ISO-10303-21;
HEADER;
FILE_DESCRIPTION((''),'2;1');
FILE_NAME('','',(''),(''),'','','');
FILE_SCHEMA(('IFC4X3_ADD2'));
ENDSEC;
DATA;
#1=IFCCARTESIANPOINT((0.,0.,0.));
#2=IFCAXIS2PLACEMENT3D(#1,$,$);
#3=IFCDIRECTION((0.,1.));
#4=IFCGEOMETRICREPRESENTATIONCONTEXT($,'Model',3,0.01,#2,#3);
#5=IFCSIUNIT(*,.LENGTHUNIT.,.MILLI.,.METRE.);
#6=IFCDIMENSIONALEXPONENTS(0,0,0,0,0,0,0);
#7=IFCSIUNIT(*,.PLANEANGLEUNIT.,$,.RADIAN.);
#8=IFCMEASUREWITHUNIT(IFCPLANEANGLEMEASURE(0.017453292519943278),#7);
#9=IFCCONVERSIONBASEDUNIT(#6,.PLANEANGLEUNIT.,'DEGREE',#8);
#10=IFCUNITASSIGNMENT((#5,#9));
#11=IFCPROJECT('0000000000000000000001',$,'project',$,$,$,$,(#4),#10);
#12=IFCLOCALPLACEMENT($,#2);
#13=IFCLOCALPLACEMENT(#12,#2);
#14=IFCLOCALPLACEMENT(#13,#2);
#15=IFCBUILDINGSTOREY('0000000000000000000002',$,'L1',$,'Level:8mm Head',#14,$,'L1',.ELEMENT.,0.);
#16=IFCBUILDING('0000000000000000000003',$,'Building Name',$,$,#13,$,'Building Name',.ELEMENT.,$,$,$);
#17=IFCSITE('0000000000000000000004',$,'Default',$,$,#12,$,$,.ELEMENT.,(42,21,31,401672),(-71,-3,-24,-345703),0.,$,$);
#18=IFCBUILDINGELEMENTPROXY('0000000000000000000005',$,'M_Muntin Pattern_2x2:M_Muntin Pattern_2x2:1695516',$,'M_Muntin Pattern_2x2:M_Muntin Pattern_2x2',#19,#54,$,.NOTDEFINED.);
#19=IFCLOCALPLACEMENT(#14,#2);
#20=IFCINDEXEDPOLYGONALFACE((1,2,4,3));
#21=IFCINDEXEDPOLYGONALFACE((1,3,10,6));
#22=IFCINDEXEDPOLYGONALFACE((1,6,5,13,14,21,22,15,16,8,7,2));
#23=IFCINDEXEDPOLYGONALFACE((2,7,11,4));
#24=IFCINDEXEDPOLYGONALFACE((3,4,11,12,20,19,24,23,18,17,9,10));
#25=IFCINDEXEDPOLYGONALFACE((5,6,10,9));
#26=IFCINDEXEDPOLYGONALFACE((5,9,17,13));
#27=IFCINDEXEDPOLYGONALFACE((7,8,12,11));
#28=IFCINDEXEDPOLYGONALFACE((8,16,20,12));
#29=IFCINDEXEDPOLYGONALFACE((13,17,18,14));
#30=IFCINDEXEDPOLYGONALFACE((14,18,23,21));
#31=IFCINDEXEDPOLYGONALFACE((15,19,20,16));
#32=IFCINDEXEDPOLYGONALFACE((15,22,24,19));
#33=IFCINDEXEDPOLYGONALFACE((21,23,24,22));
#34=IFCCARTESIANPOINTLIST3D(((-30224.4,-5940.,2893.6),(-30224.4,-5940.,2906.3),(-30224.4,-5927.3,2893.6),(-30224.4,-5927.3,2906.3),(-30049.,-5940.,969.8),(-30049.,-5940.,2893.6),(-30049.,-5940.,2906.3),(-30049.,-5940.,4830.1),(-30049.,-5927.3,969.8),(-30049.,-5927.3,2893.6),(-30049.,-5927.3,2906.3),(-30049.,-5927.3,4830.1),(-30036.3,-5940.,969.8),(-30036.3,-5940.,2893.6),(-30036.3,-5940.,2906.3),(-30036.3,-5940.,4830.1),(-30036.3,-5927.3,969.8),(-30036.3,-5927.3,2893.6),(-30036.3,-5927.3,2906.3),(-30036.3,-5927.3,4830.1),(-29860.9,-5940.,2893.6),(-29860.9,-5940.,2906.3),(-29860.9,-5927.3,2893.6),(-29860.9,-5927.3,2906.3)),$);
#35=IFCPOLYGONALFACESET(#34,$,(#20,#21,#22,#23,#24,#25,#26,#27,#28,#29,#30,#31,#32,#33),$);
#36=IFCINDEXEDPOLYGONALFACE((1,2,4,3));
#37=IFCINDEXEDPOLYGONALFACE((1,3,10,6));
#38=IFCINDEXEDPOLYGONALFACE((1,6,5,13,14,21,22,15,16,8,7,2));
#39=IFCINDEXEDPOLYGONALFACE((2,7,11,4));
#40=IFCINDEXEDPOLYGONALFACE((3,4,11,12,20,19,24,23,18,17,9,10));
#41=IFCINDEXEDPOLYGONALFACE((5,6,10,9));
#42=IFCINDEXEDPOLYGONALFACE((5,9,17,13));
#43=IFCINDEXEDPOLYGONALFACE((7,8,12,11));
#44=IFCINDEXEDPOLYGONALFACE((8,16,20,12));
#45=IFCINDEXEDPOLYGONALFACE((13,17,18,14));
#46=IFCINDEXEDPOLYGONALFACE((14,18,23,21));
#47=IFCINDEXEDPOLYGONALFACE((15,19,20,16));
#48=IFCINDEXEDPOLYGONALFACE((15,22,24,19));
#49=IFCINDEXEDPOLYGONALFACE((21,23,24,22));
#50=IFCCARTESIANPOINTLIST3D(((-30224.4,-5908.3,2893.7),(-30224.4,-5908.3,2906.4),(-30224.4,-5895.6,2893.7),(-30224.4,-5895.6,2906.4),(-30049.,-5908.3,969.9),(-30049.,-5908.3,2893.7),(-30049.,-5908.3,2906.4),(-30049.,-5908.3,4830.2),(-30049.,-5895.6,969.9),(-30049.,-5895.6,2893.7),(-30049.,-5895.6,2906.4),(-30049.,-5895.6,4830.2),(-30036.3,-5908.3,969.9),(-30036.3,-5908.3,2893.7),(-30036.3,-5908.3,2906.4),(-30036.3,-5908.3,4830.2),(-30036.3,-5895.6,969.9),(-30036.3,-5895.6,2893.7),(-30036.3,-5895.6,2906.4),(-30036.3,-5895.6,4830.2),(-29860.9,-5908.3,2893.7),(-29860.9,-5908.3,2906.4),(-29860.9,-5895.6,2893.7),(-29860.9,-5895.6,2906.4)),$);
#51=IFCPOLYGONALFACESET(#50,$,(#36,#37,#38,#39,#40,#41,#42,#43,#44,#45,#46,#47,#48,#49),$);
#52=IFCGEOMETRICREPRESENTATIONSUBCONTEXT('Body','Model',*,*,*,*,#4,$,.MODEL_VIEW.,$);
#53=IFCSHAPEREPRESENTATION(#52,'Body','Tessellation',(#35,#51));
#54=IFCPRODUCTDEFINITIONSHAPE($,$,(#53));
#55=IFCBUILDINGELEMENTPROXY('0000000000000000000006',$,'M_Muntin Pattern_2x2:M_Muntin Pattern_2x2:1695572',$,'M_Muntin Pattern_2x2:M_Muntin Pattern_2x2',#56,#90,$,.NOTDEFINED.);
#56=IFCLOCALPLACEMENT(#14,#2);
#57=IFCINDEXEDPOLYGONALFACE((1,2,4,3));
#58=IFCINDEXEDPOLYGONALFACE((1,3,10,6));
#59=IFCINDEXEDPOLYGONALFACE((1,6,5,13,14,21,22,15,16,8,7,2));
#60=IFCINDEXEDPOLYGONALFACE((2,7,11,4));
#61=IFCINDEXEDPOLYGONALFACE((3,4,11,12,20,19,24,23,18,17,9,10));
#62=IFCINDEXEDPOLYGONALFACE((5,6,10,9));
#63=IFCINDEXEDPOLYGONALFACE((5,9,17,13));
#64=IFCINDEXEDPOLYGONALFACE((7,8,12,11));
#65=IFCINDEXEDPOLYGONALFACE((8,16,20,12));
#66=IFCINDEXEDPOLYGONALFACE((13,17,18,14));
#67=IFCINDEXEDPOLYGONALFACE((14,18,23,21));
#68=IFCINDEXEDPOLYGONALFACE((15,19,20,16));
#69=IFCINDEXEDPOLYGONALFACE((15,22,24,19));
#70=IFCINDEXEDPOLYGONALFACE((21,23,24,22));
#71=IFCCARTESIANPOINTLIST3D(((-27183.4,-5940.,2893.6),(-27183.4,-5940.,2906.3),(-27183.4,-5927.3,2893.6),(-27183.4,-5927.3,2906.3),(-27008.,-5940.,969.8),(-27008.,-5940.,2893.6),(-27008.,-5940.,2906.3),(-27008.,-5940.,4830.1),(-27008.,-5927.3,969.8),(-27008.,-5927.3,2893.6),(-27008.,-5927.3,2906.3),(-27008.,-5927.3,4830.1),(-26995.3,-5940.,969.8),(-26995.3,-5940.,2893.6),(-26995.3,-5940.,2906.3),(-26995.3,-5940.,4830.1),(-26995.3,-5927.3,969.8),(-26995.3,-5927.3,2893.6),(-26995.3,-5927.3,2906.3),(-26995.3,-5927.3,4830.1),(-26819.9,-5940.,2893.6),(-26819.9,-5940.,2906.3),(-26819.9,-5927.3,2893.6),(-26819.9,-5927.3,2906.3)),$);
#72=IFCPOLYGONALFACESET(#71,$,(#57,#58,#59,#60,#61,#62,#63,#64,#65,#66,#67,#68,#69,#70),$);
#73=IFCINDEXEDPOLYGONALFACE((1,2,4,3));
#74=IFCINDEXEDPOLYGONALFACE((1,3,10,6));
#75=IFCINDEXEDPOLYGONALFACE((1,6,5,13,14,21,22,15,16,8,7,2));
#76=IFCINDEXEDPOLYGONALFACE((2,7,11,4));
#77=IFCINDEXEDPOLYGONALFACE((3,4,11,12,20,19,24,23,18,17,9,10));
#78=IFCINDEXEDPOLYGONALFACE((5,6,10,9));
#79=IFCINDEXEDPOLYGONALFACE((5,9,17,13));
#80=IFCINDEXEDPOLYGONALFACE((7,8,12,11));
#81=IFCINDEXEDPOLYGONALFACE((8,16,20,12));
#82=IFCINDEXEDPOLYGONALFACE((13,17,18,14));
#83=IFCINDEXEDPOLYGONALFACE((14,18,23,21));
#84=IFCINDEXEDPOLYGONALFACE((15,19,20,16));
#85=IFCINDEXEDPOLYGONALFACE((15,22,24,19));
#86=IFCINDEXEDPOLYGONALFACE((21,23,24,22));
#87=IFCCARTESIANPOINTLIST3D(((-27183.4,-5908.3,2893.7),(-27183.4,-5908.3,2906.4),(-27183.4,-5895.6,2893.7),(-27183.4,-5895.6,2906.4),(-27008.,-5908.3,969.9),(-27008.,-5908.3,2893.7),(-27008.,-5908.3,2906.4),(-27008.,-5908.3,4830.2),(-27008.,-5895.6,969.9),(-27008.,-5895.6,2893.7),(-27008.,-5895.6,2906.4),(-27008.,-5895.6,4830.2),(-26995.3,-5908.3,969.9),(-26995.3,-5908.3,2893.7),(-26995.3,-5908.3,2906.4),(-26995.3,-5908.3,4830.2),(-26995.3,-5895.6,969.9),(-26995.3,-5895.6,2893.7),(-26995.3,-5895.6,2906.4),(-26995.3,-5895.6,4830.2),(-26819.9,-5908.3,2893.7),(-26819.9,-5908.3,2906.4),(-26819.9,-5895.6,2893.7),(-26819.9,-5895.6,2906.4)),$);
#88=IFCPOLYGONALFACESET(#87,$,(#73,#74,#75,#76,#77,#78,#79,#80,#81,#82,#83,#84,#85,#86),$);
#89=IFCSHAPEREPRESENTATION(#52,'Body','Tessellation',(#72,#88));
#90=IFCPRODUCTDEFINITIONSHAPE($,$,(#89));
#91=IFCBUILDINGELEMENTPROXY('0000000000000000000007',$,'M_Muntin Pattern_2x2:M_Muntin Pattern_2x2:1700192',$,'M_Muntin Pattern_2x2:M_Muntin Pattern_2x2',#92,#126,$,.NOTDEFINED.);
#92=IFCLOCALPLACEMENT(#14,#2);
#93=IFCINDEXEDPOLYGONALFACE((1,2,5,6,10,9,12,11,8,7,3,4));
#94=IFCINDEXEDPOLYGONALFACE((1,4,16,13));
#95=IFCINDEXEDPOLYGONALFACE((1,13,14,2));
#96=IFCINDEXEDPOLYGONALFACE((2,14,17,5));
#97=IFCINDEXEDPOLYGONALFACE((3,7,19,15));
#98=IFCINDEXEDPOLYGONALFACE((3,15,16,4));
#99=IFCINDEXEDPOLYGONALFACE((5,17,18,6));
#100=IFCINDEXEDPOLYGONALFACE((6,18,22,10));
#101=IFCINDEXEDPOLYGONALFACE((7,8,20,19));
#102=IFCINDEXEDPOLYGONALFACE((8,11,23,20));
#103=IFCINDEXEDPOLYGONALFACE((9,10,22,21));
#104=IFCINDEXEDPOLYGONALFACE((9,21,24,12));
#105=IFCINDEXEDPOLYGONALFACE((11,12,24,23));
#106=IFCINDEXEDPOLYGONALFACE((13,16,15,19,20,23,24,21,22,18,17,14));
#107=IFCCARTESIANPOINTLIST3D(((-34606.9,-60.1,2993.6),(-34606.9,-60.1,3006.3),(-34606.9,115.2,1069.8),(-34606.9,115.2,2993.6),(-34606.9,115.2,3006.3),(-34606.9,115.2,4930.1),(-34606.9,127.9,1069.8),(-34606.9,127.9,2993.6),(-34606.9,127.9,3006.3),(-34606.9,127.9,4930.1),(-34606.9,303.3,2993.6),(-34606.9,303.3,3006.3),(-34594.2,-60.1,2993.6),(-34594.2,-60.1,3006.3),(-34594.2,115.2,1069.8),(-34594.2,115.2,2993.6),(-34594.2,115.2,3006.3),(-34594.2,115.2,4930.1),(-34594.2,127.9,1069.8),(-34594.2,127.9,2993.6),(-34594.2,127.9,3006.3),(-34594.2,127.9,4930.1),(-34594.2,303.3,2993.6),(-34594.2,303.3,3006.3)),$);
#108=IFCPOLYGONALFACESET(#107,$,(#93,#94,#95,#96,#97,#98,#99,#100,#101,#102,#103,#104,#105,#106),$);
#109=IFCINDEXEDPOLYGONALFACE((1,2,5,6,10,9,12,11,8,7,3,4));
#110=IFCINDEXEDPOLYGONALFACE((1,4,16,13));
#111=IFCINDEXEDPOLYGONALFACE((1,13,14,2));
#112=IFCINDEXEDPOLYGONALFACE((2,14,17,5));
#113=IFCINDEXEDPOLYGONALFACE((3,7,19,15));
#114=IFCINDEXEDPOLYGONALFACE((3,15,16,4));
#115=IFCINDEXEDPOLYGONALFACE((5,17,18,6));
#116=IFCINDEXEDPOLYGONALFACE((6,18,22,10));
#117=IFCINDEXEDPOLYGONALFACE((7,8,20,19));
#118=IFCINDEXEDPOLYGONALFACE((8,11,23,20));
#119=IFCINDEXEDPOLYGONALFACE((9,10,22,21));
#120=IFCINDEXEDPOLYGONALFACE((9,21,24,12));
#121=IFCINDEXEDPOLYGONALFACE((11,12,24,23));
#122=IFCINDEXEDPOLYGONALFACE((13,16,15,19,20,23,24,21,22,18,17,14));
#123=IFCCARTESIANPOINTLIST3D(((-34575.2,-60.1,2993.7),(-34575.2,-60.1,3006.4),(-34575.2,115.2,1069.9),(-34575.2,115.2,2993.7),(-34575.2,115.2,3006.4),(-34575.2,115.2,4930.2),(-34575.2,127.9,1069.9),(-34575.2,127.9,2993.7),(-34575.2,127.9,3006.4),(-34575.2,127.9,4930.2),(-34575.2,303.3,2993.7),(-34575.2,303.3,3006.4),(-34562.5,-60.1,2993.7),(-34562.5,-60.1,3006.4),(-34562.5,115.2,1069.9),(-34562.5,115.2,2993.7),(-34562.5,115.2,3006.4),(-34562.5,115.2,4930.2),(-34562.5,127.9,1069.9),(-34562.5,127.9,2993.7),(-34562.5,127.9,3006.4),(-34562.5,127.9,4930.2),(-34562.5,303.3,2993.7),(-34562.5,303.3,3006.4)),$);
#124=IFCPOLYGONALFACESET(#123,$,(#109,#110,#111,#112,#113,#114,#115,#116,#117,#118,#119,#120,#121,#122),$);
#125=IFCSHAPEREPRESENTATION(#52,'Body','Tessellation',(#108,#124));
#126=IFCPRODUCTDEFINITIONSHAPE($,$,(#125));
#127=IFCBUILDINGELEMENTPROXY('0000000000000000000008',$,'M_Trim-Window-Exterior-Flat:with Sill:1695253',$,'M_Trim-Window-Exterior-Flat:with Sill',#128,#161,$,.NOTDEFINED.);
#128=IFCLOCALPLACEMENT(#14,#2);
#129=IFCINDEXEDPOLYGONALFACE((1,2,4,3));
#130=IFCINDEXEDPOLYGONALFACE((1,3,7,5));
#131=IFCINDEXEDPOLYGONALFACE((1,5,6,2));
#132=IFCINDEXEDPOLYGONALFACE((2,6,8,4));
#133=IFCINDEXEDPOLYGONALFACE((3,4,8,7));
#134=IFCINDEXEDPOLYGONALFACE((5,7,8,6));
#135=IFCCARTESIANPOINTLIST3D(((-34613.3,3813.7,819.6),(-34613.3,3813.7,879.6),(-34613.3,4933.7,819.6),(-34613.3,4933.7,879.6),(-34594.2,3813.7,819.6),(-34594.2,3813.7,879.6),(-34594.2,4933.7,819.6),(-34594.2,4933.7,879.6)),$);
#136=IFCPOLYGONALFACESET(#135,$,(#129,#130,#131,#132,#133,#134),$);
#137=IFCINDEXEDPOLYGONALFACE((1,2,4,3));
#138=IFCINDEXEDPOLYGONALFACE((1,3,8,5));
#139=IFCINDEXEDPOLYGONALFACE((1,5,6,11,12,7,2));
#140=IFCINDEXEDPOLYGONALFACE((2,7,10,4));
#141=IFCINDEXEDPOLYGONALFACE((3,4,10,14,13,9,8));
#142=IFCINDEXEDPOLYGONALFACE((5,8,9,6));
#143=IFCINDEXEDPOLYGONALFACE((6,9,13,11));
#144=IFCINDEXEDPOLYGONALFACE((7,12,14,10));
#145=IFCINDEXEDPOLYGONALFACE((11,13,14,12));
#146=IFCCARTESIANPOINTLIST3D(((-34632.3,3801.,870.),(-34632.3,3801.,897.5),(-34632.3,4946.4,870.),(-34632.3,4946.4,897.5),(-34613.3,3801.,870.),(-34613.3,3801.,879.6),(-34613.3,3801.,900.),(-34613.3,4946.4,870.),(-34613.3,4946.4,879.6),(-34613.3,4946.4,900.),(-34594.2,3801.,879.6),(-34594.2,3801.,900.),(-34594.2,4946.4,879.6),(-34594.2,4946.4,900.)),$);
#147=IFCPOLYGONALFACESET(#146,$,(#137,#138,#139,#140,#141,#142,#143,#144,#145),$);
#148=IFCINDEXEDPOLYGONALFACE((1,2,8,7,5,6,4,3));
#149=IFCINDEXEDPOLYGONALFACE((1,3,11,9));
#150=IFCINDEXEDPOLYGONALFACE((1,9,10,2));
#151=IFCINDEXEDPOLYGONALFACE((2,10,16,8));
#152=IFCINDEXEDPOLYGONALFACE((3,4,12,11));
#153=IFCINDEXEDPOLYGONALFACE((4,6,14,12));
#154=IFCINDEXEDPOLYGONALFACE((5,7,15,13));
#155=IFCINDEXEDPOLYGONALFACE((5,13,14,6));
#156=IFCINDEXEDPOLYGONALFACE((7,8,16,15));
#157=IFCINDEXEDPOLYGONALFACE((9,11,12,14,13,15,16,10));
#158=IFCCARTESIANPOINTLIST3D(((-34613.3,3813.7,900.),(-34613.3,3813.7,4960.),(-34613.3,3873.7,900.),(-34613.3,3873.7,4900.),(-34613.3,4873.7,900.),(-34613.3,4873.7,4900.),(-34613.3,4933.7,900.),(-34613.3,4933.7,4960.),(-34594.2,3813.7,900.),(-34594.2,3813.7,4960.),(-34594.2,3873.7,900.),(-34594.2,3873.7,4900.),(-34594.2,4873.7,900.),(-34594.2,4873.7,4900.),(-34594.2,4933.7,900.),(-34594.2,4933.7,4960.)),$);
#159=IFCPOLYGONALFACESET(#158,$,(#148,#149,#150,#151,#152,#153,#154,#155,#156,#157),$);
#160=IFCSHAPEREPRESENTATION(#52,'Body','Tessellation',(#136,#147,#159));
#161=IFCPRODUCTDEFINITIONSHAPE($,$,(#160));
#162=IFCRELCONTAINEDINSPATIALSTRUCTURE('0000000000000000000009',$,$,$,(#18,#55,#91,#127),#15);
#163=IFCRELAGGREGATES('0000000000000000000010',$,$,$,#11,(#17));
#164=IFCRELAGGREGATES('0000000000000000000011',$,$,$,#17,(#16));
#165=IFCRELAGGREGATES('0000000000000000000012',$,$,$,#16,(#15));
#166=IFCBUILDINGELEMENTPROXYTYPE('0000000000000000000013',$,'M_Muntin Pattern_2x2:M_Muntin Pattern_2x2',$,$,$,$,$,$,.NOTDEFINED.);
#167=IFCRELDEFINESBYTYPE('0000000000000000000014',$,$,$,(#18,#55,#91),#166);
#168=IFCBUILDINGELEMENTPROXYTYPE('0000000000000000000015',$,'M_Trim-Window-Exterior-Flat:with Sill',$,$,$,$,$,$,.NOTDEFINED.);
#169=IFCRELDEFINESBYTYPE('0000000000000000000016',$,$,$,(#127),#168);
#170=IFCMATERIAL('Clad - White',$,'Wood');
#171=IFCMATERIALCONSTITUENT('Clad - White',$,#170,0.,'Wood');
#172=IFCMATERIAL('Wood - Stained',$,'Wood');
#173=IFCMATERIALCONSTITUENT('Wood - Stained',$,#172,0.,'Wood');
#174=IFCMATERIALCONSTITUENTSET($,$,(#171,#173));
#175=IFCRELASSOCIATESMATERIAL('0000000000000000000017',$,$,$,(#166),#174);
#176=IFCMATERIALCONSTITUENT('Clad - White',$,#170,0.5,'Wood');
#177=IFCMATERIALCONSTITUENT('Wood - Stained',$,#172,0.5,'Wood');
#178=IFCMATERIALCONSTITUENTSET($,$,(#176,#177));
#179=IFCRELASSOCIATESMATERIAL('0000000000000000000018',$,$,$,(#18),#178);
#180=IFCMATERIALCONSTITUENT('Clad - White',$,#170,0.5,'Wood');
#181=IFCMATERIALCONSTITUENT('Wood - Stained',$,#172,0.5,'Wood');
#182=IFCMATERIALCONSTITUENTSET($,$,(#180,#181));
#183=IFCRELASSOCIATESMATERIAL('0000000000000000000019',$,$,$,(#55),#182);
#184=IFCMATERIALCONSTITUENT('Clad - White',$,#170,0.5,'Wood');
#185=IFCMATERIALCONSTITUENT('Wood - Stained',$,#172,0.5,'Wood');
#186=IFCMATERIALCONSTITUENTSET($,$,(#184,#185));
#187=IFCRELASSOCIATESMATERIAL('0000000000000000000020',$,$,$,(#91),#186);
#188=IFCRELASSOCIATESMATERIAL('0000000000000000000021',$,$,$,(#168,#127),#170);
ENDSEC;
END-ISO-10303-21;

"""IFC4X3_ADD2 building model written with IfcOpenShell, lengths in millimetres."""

from ifc_helpers import new_model, entity, si_unit, converted_unit, direction, frame, frame_2d, origin, place, context, subcontext, project, spatial, polyline, rectangle, outline, extrude, source, transform, mapped, material, constituent, constituent_set, type_object, type_shapes, element, save


model = new_model("IFC4X3_ADD2")

# Units and contexts
model_context = context("Model", 3, precision=0.01, world=origin(), true_north=direction((0.0, 1.0)))
body_context = subcontext(model_context, "Body", "Model", "MODEL_VIEW")
ifc_project = project(units=[si_unit("LENGTHUNIT", "METRE", prefix="MILLI"), converted_unit("PLANEANGLEUNIT", "DEGREE", entity("IfcPlaneAngleMeasure", 0.017453292519943278), si_unit("PLANEANGLEUNIT", "RADIAN"), dimensions=[0, 0, 0, 0, 0, 0, 0])], contexts=[model_context])

# Site, building, storey
site_placement = place(None, origin())
site = spatial("IfcSite", under=ifc_project, at=site_placement, Name="Default", CompositionType="ELEMENT", RefLatitude=(42, 21, 31, 401672), RefLongitude=(-71, -3, -24, -345703), RefElevation=0.0)
building_placement = place(site_placement, origin())
building = spatial("IfcBuilding", under=site, at=building_placement, Name="Building Name", LongName="Building Name", CompositionType="ELEMENT")
storey_placement = place(building_placement, origin())
storey = spatial("IfcBuildingStorey", under=building, at=storey_placement, Name="L1", ObjectType="Level:8mm Head", LongName="L1", CompositionType="ELEMENT", Elevation=0.0)

# Building element proxies
ifc_material_1 = material(Name="Clad - White", Category="Wood")
ifc_material_2 = material(Name="Wood - Stained", Category="Wood")
ifc_constituent_1 = constituent(ifc_material_1, Name="Clad - White", Category="Wood", fraction=0.0)
ifc_constituent_2 = constituent(ifc_material_2, Name="Wood - Stained", Category="Wood", fraction=0.0)
ifc_constituent_set_1 = constituent_set(constituents=[ifc_constituent_1, ifc_constituent_2])
building_element_proxy_type_1 = type_object("IfcBuildingElementProxyType", Name="M_Muntin Pattern_2x2:M_Muntin Pattern_2x2", PredefinedType="NOTDEFINED", material=ifc_constituent_set_1)
shared_shape_1 = source(origin(), body_context, "Body", "SweptSolid", [
    extrude(outline(polyline([(6.4, -6.4), (1930.1, -6.4), (1930.1, 6.3), (6.4, 6.3), (6.4, 181.7), (-6.3, 181.7), (-6.3, 6.3), (-1930.2, 6.3), (-1930.2, -6.4), (-6.3, -6.4), (-6.3, -181.7), (6.4, -181.7), (6.4, -6.4)])), frame((0.0, -22.2, 1930.1), z_axis=(0.0, 1.0, 0.0), x_axis=(0.0, 0.0, 1.0)), (0.0, 0.0, 1.0), 12.7),
    extrude(outline(polyline([(6.4, -6.4), (1930.2, -6.4), (1930.2, 6.3), (6.4, 6.3), (6.4, 181.7), (-6.3, 181.7), (-6.3, 6.3), (-1930.2, 6.3), (-1930.2, -6.4), (-6.3, -6.4), (-6.3, -181.7), (6.4, -181.7), (6.4, -6.4)])), frame((0.0, 9.5, 1930.2), z_axis=(0.0, 1.0, 0.0), x_axis=(0.0, 0.0, 1.0)), (0.0, 0.0, 1.0), 12.7),
])
type_shapes(building_element_proxy_type_1, [shared_shape_1])
ifc_constituent_3 = constituent(ifc_material_1, Name="Clad - White", Category="Wood", fraction=0.5)
ifc_constituent_4 = constituent(ifc_material_2, Name="Wood - Stained", Category="Wood", fraction=0.5)
ifc_constituent_set_2 = constituent_set(constituents=[ifc_constituent_3, ifc_constituent_4])
proxy_1_placement = place(storey_placement, frame((-30042.6, -5917.8, 969.9)))
element("IfcBuildingElementProxy", 1, at=proxy_1_placement, inside=storey, type_object=building_element_proxy_type_1, material=ifc_constituent_set_2, Name="M_Muntin Pattern_2x2:M_Muntin Pattern_2x2:1695516", ObjectType="M_Muntin Pattern_2x2:M_Muntin Pattern_2x2", PredefinedType="NOTDEFINED", context=body_context, shape_type="MappedRepresentation", body=[
    mapped(shared_shape_1, transform((0.0, 0.0, 0.0), scale=1.0)),
])
ifc_constituent_5 = constituent(ifc_material_1, Name="Clad - White", Category="Wood", fraction=0.5)
ifc_constituent_6 = constituent(ifc_material_2, Name="Wood - Stained", Category="Wood", fraction=0.5)
ifc_constituent_set_3 = constituent_set(constituents=[ifc_constituent_5, ifc_constituent_6])
proxy_2_placement = place(storey_placement, frame((-27001.6, -5917.8, 969.9)))
element("IfcBuildingElementProxy", 2, at=proxy_2_placement, inside=storey, type_object=building_element_proxy_type_1, material=ifc_constituent_set_3, Name="M_Muntin Pattern_2x2:M_Muntin Pattern_2x2:1695572", ObjectType="M_Muntin Pattern_2x2:M_Muntin Pattern_2x2", PredefinedType="NOTDEFINED", context=body_context, shape_type="MappedRepresentation", body=[
    mapped(shared_shape_1, transform((0.0, 0.0, 0.0), scale=1.0)),
])
ifc_constituent_7 = constituent(ifc_material_1, Name="Clad - White", Category="Wood", fraction=0.5)
ifc_constituent_8 = constituent(ifc_material_2, Name="Wood - Stained", Category="Wood", fraction=0.5)
ifc_constituent_set_4 = constituent_set(constituents=[ifc_constituent_7, ifc_constituent_8])
proxy_3_placement = place(storey_placement, frame((-34584.7, 121.6, 1069.9), z_axis=(0.0, 0.0, 1.0), x_axis=(0.0, -1.0, 0.0)))
element("IfcBuildingElementProxy", 3, at=proxy_3_placement, inside=storey, type_object=building_element_proxy_type_1, material=ifc_constituent_set_4, Name="M_Muntin Pattern_2x2:M_Muntin Pattern_2x2:1700192", ObjectType="M_Muntin Pattern_2x2:M_Muntin Pattern_2x2", PredefinedType="NOTDEFINED", context=body_context, shape_type="MappedRepresentation", body=[
    mapped(shared_shape_1, transform((0.0, 0.0, 0.0), scale=1.0)),
])
building_element_proxy_type_2 = type_object("IfcBuildingElementProxyType", Name="M_Trim-Window-Exterior-Flat:with Sill", PredefinedType="NOTDEFINED", material=ifc_material_1)
shared_shape_2 = source(origin(), body_context, "Body", "SweptSolid", [
    extrude(rectangle(XDim=1120.0, YDim=60.0, at=frame_2d((0.0, 0.0), x_axis=(1.0, 0.0))), frame((0.0, -4050.4, 0.0), z_axis=(0.0, 0.0, 1.0), x_axis=(-1.0, 0.0, 0.0)), (0.0, 0.0, 1.0), 19.0),
    extrude(outline(polyline([(-19.0, -15.2), (0.0, -15.2), (0.0, -5.7), (19.0, -5.7), (19.0, 14.8), (0.0, 14.8), (-19.0, 12.3), (-19.0, -15.2)])), frame((-572.7, -4014.8, 19.0), z_axis=(1.0, 0.0, 0.0), x_axis=(0.0, 0.0, -1.0)), (0.0, 0.0, 1.0), 1145.4),
    extrude(outline(polyline([(-2045.0, -560.0), (2015.0, -560.0), (2015.0, -500.0), (-1985.0, -500.0), (-1985.0, 500.0), (2015.0, 500.0), (2015.0, 560.0), (-2045.0, 560.0), (-2045.0, -560.0)])), frame((0.0, -1985.0, 0.0), z_axis=(0.0, 0.0, 1.0), x_axis=(0.0, -1.0, 0.0)), (0.0, 0.0, 1.0), 19.0),
])
type_shapes(building_element_proxy_type_2, [shared_shape_2])
for number, where, z_axis, x_axis, name in (
    (4, (-34594.2, 4373.7, 4900.0), (-1.0, 0.0, 0.0), (0.0, -1.0, 0.0), "M_Trim-Window-Exterior-Flat:with Sill:1695253"),
):
    element("IfcBuildingElementProxy", number, at=place(storey_placement, frame(where, z_axis=z_axis, x_axis=x_axis)), inside=storey, type_object=building_element_proxy_type_2, material=ifc_material_1, Name=name, ObjectType="M_Trim-Window-Exterior-Flat:with Sill", PredefinedType="NOTDEFINED", context=body_context, shape_type="MappedRepresentation", body=[
        mapped(shared_shape_2, transform((0.0, 0.0, 0.0), scale=1.0)),
    ])

save(model, "model.ifc")
